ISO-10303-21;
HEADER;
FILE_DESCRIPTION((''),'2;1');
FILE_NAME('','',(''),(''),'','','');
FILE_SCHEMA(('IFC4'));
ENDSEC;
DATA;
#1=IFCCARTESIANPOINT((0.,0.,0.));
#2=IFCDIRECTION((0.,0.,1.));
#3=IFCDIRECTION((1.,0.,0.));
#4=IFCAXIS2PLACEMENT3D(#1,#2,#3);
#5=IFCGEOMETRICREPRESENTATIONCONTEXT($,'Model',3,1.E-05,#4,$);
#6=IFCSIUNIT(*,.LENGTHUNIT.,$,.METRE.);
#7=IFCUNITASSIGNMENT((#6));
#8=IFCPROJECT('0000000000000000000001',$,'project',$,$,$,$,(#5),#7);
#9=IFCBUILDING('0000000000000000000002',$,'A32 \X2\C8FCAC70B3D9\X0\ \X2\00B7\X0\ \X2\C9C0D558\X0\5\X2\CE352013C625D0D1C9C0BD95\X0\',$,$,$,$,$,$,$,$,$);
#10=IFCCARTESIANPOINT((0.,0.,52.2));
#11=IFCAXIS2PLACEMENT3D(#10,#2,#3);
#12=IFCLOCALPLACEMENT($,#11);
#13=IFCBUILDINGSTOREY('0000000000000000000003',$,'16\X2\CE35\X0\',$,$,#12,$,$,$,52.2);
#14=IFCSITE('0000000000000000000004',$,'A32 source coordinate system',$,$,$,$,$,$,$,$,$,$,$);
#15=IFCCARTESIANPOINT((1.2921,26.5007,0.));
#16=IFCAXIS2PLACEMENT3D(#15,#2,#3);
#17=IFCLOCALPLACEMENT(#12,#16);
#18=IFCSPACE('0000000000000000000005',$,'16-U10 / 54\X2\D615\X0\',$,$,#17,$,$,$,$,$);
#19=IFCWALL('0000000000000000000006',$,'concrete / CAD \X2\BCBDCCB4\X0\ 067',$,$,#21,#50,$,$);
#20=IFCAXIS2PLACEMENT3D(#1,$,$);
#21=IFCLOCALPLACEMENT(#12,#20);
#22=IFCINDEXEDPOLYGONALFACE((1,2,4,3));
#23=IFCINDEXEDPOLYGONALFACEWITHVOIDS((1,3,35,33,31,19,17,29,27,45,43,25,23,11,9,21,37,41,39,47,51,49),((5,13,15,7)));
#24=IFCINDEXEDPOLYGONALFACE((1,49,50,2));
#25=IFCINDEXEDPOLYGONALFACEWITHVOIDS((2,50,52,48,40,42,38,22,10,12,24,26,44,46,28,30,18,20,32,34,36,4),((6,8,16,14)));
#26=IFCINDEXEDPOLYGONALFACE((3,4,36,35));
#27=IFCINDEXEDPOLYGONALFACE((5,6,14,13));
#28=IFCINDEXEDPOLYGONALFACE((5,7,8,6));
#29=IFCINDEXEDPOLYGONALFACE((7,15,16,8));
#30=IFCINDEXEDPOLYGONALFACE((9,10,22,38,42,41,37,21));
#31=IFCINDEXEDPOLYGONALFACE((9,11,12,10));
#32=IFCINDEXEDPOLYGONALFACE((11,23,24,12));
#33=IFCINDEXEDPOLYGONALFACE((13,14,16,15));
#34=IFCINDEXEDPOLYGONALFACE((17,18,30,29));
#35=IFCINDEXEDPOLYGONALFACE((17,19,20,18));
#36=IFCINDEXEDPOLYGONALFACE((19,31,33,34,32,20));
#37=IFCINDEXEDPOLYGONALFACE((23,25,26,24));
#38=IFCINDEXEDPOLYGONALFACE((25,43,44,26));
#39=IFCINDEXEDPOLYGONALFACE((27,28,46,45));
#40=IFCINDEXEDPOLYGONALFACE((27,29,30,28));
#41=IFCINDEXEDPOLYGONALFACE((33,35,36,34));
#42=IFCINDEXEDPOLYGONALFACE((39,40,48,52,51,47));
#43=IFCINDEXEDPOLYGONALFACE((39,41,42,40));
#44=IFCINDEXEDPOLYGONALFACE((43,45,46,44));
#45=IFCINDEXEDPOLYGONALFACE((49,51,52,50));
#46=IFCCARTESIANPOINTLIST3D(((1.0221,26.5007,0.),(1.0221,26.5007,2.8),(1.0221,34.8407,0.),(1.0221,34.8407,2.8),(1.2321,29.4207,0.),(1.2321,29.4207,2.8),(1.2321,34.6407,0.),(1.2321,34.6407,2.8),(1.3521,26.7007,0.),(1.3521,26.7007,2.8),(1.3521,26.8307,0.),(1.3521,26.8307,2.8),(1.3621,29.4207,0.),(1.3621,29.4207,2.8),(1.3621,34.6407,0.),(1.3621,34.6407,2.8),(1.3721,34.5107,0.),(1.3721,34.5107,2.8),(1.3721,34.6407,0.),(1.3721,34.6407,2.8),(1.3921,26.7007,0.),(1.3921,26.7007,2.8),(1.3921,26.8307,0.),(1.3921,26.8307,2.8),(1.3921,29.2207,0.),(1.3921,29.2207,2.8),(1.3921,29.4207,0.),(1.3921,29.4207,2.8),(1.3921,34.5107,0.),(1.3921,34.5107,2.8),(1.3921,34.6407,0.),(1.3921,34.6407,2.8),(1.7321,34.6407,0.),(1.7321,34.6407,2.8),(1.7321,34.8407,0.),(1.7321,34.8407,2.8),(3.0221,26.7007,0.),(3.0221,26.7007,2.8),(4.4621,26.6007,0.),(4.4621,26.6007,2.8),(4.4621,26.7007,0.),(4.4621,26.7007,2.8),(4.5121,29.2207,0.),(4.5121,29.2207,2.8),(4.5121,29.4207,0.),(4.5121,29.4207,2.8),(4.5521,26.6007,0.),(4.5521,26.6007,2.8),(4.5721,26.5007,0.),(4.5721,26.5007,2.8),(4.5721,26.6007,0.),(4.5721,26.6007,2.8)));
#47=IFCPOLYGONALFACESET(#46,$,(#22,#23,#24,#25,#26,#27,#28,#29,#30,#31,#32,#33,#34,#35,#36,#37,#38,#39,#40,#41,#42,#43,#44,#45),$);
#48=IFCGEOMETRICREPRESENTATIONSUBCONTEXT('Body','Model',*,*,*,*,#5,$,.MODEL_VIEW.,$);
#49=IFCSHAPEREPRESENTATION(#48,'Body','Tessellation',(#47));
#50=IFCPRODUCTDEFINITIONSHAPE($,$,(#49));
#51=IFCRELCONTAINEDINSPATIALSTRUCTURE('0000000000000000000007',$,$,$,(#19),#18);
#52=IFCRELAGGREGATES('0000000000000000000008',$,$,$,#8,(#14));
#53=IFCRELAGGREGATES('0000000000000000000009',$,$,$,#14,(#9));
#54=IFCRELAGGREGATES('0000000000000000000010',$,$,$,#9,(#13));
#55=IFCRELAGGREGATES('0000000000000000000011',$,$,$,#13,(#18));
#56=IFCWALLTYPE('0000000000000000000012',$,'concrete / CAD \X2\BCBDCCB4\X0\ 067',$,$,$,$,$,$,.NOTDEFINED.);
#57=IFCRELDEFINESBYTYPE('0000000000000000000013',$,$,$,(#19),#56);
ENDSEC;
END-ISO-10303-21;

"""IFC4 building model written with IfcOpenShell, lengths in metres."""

from ifc_helpers import new_model, si_unit, frame, origin, origin_with_axes, place, context, subcontext, project, spatial, polyline, outline, extrude, source, transform, mapped, type_object, type_shapes, element, save


model = new_model("IFC4")

# Units and contexts
model_context = context("Model", 3, precision=1e-05, world=origin_with_axes())
body_context = subcontext(model_context, "Body", "Model", "MODEL_VIEW")
ifc_project = project(units=[si_unit("LENGTHUNIT", "METRE")], contexts=[model_context])

# Site, building, storey, space
site = spatial("IfcSite", under=ifc_project, Name="A32 source coordinate system")
building = spatial("IfcBuilding", under=site, Name="A32 주거동 · 지하5층–옥탑지붕")
storey_placement = place(None, frame((0.0, 0.0, 52.2), z_axis=(0.0, 0.0, 1.0), x_axis=(1.0, 0.0, 0.0)))
storey = spatial("IfcBuildingStorey", under=building, at=storey_placement, Name="16층", Elevation=52.2)
space_placement = place(storey_placement, frame((1.2921, 26.5007, 0.0), z_axis=(0.0, 0.0, 1.0), x_axis=(1.0, 0.0, 0.0)))
space = spatial("IfcSpace", under=storey, at=space_placement, Name="16-U10 / 54형")

# Wall
wall_type_1 = type_object("IfcWallType", Name="concrete / CAD 벽체 067", PredefinedType="NOTDEFINED")
shared_shape_1 = source(origin(), body_context, "Body", "SweptSolid", [
    extrude(outline(polyline([(0.1, 0.2), (1.73, 0.2), (3.17, 0.2), (3.17, 0.1), (3.26, 0.1), (3.28, 0.1), (3.28, 0.0), (-0.27, 0.0), (-0.27, 8.34), (0.44, 8.34), (0.44, 8.14), (0.1, 8.14), (0.08, 8.14), (0.08, 8.01), (0.1, 8.01), (0.1, 2.92), (3.22, 2.92), (3.22, 2.72), (0.1, 2.72), (0.1, 0.33), (0.06, 0.33), (0.06, 0.2), (0.1, 0.2)]), holes=[polyline([(-0.06, 8.14), (-0.06, 2.92), (0.07, 2.92), (0.07, 8.14), (-0.06, 8.14)])]), origin(), (0.0, 0.0, 1.0), 2.8),
])
type_shapes(wall_type_1, [shared_shape_1])
wall_1_placement = place(space_placement, origin_with_axes())
element("IfcWall", 1, at=wall_1_placement, inside=space, type_object=wall_type_1, Name="concrete / CAD 벽체 067", context=body_context, shape_type="MappedRepresentation", body=[
    mapped(shared_shape_1, transform((0.0, 0.0, 0.0), scale=1.0)),
])

save(model, "model.ifc")
